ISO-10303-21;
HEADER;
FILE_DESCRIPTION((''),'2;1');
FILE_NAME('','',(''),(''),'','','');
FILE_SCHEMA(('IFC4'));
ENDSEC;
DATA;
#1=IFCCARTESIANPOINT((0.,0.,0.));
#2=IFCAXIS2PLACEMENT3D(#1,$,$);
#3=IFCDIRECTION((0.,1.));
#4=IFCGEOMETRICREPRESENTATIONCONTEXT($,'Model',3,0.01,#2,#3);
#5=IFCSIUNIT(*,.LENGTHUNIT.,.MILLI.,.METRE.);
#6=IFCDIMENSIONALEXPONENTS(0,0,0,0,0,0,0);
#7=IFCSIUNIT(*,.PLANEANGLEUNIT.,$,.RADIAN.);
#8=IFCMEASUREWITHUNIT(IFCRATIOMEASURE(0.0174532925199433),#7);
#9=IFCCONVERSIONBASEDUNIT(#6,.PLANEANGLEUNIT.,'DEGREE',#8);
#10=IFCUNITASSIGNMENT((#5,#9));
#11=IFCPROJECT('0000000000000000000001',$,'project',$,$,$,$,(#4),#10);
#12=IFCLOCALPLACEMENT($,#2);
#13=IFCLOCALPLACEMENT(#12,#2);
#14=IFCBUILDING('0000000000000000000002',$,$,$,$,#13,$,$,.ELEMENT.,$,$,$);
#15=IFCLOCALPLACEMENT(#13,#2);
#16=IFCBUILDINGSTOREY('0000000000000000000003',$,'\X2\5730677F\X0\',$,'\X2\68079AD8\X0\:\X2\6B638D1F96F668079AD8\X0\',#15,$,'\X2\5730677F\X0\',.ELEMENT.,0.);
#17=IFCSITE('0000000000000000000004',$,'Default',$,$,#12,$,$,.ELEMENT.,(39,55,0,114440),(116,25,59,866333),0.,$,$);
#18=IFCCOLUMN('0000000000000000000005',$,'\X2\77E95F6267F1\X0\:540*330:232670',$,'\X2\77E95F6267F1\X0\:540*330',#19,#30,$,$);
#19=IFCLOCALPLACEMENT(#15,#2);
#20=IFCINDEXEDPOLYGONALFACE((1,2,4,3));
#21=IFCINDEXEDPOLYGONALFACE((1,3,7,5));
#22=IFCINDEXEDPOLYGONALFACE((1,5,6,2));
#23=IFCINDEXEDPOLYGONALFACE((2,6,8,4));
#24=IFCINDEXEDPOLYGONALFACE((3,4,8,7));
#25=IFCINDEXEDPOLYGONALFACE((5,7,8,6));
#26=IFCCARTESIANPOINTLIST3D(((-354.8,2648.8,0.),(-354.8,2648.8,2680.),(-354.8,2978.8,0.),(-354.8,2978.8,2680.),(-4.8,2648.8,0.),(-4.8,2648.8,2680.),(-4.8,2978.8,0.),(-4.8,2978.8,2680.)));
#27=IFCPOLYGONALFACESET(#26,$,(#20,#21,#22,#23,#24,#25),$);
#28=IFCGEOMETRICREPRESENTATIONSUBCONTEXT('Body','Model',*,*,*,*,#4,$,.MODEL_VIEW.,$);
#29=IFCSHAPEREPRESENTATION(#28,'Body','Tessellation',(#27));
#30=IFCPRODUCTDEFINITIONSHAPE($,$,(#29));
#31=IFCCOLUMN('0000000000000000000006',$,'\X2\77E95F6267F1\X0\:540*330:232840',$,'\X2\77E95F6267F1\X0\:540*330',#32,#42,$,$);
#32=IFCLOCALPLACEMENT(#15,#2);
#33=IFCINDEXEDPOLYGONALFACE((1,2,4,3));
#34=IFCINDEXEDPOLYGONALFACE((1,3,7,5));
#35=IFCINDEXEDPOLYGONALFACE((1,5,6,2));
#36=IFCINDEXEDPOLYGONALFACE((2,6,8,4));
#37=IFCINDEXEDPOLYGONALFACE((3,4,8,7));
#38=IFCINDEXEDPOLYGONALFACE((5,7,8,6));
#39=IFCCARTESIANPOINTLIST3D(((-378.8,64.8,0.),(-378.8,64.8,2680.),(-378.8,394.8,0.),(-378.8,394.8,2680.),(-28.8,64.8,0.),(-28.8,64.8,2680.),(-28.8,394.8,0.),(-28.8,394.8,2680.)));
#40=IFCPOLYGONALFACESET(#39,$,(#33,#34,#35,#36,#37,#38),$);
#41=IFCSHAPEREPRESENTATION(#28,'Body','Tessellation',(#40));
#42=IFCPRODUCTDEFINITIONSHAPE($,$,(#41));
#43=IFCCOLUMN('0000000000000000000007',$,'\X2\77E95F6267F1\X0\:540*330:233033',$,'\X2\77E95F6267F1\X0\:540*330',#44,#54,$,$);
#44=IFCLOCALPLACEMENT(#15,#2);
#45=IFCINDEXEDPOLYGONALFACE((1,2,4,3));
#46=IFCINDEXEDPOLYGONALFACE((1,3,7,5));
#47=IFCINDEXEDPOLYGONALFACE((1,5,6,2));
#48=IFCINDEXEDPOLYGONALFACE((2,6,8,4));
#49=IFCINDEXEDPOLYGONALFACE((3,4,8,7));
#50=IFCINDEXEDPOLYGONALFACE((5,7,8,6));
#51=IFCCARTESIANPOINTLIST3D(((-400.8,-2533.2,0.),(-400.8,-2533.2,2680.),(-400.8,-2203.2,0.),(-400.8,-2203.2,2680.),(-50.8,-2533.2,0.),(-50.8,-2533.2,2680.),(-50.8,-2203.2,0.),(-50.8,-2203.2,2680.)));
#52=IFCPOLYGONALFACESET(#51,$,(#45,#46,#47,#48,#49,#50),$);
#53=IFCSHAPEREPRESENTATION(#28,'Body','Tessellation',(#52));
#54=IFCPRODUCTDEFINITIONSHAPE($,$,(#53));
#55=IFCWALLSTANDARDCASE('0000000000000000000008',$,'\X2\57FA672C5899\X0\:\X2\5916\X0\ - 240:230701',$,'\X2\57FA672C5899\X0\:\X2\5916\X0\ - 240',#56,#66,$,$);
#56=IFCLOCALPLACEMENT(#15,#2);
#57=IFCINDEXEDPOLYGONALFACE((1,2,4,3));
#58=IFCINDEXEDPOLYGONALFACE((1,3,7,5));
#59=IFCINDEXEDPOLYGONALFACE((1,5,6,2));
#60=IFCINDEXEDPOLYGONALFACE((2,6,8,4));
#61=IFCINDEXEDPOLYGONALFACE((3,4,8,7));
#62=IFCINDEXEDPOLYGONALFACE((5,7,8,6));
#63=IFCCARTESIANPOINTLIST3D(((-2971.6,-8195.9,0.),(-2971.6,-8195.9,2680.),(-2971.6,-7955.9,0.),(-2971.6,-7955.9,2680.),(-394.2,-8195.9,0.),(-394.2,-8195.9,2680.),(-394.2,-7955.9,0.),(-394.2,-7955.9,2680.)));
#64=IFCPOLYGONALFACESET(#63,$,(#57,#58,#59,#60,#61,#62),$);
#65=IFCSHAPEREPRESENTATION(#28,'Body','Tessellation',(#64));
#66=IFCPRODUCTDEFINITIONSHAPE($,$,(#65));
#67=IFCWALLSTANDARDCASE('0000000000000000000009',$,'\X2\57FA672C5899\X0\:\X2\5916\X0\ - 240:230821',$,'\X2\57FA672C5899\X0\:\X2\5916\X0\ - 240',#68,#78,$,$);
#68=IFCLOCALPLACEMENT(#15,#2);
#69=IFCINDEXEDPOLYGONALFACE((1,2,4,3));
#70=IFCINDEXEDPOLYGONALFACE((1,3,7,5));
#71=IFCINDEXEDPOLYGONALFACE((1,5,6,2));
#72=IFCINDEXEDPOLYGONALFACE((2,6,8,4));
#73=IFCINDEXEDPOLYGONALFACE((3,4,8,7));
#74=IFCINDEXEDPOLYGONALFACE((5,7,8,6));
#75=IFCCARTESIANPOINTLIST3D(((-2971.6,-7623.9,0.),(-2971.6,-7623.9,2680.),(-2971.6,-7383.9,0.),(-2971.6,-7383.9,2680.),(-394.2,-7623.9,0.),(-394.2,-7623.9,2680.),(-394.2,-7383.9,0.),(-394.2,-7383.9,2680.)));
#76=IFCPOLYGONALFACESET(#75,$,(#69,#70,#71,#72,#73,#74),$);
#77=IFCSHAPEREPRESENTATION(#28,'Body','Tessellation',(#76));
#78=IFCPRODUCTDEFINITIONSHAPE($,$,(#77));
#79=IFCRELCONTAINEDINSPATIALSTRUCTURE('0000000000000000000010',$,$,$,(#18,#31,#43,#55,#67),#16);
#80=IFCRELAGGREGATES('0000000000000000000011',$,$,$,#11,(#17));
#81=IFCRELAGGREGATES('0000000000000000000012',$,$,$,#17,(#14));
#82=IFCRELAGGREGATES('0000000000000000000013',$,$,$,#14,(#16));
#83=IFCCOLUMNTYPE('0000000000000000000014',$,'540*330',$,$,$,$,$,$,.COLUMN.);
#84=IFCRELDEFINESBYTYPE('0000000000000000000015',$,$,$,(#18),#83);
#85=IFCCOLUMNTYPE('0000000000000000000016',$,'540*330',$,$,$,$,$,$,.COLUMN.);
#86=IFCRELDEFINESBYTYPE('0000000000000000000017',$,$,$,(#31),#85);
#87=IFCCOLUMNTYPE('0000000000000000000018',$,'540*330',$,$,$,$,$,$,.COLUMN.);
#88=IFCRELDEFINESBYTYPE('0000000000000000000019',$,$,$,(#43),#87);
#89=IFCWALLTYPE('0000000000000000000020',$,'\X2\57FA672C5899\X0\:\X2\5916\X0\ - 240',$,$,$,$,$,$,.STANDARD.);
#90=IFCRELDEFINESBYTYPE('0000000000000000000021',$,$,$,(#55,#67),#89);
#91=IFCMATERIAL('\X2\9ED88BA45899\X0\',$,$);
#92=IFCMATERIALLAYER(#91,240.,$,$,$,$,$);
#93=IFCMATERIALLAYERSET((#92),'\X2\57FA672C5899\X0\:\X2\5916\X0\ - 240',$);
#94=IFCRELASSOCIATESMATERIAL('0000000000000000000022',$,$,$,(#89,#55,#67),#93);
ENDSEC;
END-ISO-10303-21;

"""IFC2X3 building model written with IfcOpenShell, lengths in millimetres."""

from ifc_helpers import new_model, entity, si_unit, converted_unit, direction, frame, frame_2d, origin, origin_2d_with_axis, place, context, subcontext, project, spatial, rectangle, extrude, source, transform, mapped, material, layer, layer_set, layer_usage, type_object, type_shapes, element, save


model = new_model("IFC2X3")

# Units and contexts
model_context = context("Model", 3, precision=0.01, world=origin(), true_north=direction((0.0, 1.0)))
body_context = subcontext(model_context, "Body", "Model", "MODEL_VIEW")
ifc_project = project(units=[si_unit("LENGTHUNIT", "METRE", prefix="MILLI"), converted_unit("PLANEANGLEUNIT", "DEGREE", entity("IfcRatioMeasure", 0.0174532925199433), si_unit("PLANEANGLEUNIT", "RADIAN"), dimensions=[0, 0, 0, 0, 0, 0, 0])], contexts=[model_context])

# Site, building, storey
site_placement = place(None, origin())
site = spatial("IfcSite", under=ifc_project, at=site_placement, Name="Default", CompositionType="ELEMENT", RefLatitude=(39, 55, 0, 114440), RefLongitude=(116, 25, 59, 866333), RefElevation=0.0)
building_placement = place(site_placement, origin())
building = spatial("IfcBuilding", under=site, at=building_placement, CompositionType="ELEMENT")
storey_placement = place(building_placement, origin())
storey = spatial("IfcBuildingStorey", under=building, at=storey_placement, Name="地板", ObjectType="标高:正负零标高", LongName="地板", CompositionType="ELEMENT", Elevation=0.0)

# Columns
ifc_material_1 = material(Name="默认墙")
column_type_1 = type_object("IfcColumnType", Name="540*330", PredefinedType="COLUMN")
shared_shape_1 = source(origin(), body_context, "Body", "SweptSolid", [
    extrude(rectangle(XDim=330.0, YDim=350.0, at=frame_2d((0.0, 0.0), x_axis=(1.0, 0.0))), frame((-179.8, 2813.8, 0.0), z_axis=(0.0, 0.0, 1.0), x_axis=(0.0, -1.0, 0.0)), (0.0, 0.0, 1.0), 2680.0),
])
type_shapes(column_type_1, [shared_shape_1])
column_1_placement = place(storey_placement, origin())
element("IfcColumn", 1, at=column_1_placement, inside=storey, type_object=column_type_1, Name="矩形柱:540*330:232670", ObjectType="矩形柱:540*330", context=body_context, shape_type="MappedRepresentation", body=[
    mapped(shared_shape_1, transform((0.0, 0.0, 0.0), scale=1.0)),
])
column_type_2 = type_object("IfcColumnType", Name="540*330", PredefinedType="COLUMN")
shared_shape_2 = source(origin(), body_context, "Body", "SweptSolid", [
    extrude(rectangle(XDim=330.0, YDim=350.0, at=origin_2d_with_axis()), frame((-203.8, 229.8, 0.0), z_axis=(0.0, 0.0, 1.0), x_axis=(0.0, -1.0, 0.0)), (0.0, 0.0, 1.0), 2680.0),
])
type_shapes(column_type_2, [shared_shape_2])
column_2_placement = place(storey_placement, origin())
element("IfcColumn", 2, at=column_2_placement, inside=storey, type_object=column_type_2, Name="矩形柱:540*330:232840", ObjectType="矩形柱:540*330", context=body_context, shape_type="MappedRepresentation", body=[
    mapped(shared_shape_2, transform((0.0, 0.0, 0.0), scale=1.0)),
])
column_type_3 = type_object("IfcColumnType", Name="540*330", PredefinedType="COLUMN")
shared_shape_3 = source(origin(), body_context, "Body", "SweptSolid", [
    extrude(rectangle(XDim=330.0, YDim=350.0, at=frame_2d((0.0, 0.0), x_axis=(1.0, 0.0))), frame((-225.8, -2368.2, 0.0), z_axis=(0.0, 0.0, 1.0), x_axis=(0.0, -1.0, 0.0)), (0.0, 0.0, 1.0), 2680.0),
])
type_shapes(column_type_3, [shared_shape_3])
column_3_placement = place(storey_placement, origin())
element("IfcColumn", 3, at=column_3_placement, inside=storey, type_object=column_type_3, Name="矩形柱:540*330:233033", ObjectType="矩形柱:540*330", context=body_context, shape_type="MappedRepresentation", body=[
    mapped(shared_shape_3, transform((0.0, 0.0, 0.0), scale=1.0)),
])

# Walls
ifc_layer_1 = layer(ifc_material_1, 240.0)
ifc_layer_set_1 = layer_set([ifc_layer_1], Name="基本墙:外 - 240")
ifc_layer_usage_1 = layer_usage(ifc_layer_set_1, "AXIS2", "NEGATIVE", 120.0)
wall_type_1 = type_object("IfcWallType", Name="基本墙:外 - 240", PredefinedType="STANDARD", material=ifc_layer_set_1)
wall_1_placement = place(storey_placement, frame((-2971.6, -8075.9, 0.0)))
element("IfcWallStandardCase", 4, at=wall_1_placement, inside=storey, type_object=wall_type_1, material=ifc_layer_usage_1, Name="基本墙:外 - 240:230701", ObjectType="基本墙:外 - 240", context=body_context, shape_type="SweptSolid", body=[
    extrude(rectangle(XDim=2577.4, YDim=240.0, at=frame_2d((1288.7, 0.0), x_axis=(-1.0, 0.0))), origin(), (0.0, 0.0, 1.0), 2680.0),
])
ifc_layer_usage_2 = layer_usage(ifc_layer_set_1, "AXIS2", "NEGATIVE", 120.0)
wall_2_placement = place(storey_placement, frame((-2971.6, -7503.9, 0.0)))
element("IfcWallStandardCase", 5, at=wall_2_placement, inside=storey, type_object=wall_type_1, material=ifc_layer_usage_2, Name="基本墙:外 - 240:230821", ObjectType="基本墙:外 - 240", context=body_context, shape_type="SweptSolid", body=[
    extrude(rectangle(XDim=2577.4, YDim=240.0, at=frame_2d((1288.7, 0.0), x_axis=(-1.0, 0.0))), origin(), (0.0, 0.0, 1.0), 2680.0),
])

save(model, "model.ifc")
